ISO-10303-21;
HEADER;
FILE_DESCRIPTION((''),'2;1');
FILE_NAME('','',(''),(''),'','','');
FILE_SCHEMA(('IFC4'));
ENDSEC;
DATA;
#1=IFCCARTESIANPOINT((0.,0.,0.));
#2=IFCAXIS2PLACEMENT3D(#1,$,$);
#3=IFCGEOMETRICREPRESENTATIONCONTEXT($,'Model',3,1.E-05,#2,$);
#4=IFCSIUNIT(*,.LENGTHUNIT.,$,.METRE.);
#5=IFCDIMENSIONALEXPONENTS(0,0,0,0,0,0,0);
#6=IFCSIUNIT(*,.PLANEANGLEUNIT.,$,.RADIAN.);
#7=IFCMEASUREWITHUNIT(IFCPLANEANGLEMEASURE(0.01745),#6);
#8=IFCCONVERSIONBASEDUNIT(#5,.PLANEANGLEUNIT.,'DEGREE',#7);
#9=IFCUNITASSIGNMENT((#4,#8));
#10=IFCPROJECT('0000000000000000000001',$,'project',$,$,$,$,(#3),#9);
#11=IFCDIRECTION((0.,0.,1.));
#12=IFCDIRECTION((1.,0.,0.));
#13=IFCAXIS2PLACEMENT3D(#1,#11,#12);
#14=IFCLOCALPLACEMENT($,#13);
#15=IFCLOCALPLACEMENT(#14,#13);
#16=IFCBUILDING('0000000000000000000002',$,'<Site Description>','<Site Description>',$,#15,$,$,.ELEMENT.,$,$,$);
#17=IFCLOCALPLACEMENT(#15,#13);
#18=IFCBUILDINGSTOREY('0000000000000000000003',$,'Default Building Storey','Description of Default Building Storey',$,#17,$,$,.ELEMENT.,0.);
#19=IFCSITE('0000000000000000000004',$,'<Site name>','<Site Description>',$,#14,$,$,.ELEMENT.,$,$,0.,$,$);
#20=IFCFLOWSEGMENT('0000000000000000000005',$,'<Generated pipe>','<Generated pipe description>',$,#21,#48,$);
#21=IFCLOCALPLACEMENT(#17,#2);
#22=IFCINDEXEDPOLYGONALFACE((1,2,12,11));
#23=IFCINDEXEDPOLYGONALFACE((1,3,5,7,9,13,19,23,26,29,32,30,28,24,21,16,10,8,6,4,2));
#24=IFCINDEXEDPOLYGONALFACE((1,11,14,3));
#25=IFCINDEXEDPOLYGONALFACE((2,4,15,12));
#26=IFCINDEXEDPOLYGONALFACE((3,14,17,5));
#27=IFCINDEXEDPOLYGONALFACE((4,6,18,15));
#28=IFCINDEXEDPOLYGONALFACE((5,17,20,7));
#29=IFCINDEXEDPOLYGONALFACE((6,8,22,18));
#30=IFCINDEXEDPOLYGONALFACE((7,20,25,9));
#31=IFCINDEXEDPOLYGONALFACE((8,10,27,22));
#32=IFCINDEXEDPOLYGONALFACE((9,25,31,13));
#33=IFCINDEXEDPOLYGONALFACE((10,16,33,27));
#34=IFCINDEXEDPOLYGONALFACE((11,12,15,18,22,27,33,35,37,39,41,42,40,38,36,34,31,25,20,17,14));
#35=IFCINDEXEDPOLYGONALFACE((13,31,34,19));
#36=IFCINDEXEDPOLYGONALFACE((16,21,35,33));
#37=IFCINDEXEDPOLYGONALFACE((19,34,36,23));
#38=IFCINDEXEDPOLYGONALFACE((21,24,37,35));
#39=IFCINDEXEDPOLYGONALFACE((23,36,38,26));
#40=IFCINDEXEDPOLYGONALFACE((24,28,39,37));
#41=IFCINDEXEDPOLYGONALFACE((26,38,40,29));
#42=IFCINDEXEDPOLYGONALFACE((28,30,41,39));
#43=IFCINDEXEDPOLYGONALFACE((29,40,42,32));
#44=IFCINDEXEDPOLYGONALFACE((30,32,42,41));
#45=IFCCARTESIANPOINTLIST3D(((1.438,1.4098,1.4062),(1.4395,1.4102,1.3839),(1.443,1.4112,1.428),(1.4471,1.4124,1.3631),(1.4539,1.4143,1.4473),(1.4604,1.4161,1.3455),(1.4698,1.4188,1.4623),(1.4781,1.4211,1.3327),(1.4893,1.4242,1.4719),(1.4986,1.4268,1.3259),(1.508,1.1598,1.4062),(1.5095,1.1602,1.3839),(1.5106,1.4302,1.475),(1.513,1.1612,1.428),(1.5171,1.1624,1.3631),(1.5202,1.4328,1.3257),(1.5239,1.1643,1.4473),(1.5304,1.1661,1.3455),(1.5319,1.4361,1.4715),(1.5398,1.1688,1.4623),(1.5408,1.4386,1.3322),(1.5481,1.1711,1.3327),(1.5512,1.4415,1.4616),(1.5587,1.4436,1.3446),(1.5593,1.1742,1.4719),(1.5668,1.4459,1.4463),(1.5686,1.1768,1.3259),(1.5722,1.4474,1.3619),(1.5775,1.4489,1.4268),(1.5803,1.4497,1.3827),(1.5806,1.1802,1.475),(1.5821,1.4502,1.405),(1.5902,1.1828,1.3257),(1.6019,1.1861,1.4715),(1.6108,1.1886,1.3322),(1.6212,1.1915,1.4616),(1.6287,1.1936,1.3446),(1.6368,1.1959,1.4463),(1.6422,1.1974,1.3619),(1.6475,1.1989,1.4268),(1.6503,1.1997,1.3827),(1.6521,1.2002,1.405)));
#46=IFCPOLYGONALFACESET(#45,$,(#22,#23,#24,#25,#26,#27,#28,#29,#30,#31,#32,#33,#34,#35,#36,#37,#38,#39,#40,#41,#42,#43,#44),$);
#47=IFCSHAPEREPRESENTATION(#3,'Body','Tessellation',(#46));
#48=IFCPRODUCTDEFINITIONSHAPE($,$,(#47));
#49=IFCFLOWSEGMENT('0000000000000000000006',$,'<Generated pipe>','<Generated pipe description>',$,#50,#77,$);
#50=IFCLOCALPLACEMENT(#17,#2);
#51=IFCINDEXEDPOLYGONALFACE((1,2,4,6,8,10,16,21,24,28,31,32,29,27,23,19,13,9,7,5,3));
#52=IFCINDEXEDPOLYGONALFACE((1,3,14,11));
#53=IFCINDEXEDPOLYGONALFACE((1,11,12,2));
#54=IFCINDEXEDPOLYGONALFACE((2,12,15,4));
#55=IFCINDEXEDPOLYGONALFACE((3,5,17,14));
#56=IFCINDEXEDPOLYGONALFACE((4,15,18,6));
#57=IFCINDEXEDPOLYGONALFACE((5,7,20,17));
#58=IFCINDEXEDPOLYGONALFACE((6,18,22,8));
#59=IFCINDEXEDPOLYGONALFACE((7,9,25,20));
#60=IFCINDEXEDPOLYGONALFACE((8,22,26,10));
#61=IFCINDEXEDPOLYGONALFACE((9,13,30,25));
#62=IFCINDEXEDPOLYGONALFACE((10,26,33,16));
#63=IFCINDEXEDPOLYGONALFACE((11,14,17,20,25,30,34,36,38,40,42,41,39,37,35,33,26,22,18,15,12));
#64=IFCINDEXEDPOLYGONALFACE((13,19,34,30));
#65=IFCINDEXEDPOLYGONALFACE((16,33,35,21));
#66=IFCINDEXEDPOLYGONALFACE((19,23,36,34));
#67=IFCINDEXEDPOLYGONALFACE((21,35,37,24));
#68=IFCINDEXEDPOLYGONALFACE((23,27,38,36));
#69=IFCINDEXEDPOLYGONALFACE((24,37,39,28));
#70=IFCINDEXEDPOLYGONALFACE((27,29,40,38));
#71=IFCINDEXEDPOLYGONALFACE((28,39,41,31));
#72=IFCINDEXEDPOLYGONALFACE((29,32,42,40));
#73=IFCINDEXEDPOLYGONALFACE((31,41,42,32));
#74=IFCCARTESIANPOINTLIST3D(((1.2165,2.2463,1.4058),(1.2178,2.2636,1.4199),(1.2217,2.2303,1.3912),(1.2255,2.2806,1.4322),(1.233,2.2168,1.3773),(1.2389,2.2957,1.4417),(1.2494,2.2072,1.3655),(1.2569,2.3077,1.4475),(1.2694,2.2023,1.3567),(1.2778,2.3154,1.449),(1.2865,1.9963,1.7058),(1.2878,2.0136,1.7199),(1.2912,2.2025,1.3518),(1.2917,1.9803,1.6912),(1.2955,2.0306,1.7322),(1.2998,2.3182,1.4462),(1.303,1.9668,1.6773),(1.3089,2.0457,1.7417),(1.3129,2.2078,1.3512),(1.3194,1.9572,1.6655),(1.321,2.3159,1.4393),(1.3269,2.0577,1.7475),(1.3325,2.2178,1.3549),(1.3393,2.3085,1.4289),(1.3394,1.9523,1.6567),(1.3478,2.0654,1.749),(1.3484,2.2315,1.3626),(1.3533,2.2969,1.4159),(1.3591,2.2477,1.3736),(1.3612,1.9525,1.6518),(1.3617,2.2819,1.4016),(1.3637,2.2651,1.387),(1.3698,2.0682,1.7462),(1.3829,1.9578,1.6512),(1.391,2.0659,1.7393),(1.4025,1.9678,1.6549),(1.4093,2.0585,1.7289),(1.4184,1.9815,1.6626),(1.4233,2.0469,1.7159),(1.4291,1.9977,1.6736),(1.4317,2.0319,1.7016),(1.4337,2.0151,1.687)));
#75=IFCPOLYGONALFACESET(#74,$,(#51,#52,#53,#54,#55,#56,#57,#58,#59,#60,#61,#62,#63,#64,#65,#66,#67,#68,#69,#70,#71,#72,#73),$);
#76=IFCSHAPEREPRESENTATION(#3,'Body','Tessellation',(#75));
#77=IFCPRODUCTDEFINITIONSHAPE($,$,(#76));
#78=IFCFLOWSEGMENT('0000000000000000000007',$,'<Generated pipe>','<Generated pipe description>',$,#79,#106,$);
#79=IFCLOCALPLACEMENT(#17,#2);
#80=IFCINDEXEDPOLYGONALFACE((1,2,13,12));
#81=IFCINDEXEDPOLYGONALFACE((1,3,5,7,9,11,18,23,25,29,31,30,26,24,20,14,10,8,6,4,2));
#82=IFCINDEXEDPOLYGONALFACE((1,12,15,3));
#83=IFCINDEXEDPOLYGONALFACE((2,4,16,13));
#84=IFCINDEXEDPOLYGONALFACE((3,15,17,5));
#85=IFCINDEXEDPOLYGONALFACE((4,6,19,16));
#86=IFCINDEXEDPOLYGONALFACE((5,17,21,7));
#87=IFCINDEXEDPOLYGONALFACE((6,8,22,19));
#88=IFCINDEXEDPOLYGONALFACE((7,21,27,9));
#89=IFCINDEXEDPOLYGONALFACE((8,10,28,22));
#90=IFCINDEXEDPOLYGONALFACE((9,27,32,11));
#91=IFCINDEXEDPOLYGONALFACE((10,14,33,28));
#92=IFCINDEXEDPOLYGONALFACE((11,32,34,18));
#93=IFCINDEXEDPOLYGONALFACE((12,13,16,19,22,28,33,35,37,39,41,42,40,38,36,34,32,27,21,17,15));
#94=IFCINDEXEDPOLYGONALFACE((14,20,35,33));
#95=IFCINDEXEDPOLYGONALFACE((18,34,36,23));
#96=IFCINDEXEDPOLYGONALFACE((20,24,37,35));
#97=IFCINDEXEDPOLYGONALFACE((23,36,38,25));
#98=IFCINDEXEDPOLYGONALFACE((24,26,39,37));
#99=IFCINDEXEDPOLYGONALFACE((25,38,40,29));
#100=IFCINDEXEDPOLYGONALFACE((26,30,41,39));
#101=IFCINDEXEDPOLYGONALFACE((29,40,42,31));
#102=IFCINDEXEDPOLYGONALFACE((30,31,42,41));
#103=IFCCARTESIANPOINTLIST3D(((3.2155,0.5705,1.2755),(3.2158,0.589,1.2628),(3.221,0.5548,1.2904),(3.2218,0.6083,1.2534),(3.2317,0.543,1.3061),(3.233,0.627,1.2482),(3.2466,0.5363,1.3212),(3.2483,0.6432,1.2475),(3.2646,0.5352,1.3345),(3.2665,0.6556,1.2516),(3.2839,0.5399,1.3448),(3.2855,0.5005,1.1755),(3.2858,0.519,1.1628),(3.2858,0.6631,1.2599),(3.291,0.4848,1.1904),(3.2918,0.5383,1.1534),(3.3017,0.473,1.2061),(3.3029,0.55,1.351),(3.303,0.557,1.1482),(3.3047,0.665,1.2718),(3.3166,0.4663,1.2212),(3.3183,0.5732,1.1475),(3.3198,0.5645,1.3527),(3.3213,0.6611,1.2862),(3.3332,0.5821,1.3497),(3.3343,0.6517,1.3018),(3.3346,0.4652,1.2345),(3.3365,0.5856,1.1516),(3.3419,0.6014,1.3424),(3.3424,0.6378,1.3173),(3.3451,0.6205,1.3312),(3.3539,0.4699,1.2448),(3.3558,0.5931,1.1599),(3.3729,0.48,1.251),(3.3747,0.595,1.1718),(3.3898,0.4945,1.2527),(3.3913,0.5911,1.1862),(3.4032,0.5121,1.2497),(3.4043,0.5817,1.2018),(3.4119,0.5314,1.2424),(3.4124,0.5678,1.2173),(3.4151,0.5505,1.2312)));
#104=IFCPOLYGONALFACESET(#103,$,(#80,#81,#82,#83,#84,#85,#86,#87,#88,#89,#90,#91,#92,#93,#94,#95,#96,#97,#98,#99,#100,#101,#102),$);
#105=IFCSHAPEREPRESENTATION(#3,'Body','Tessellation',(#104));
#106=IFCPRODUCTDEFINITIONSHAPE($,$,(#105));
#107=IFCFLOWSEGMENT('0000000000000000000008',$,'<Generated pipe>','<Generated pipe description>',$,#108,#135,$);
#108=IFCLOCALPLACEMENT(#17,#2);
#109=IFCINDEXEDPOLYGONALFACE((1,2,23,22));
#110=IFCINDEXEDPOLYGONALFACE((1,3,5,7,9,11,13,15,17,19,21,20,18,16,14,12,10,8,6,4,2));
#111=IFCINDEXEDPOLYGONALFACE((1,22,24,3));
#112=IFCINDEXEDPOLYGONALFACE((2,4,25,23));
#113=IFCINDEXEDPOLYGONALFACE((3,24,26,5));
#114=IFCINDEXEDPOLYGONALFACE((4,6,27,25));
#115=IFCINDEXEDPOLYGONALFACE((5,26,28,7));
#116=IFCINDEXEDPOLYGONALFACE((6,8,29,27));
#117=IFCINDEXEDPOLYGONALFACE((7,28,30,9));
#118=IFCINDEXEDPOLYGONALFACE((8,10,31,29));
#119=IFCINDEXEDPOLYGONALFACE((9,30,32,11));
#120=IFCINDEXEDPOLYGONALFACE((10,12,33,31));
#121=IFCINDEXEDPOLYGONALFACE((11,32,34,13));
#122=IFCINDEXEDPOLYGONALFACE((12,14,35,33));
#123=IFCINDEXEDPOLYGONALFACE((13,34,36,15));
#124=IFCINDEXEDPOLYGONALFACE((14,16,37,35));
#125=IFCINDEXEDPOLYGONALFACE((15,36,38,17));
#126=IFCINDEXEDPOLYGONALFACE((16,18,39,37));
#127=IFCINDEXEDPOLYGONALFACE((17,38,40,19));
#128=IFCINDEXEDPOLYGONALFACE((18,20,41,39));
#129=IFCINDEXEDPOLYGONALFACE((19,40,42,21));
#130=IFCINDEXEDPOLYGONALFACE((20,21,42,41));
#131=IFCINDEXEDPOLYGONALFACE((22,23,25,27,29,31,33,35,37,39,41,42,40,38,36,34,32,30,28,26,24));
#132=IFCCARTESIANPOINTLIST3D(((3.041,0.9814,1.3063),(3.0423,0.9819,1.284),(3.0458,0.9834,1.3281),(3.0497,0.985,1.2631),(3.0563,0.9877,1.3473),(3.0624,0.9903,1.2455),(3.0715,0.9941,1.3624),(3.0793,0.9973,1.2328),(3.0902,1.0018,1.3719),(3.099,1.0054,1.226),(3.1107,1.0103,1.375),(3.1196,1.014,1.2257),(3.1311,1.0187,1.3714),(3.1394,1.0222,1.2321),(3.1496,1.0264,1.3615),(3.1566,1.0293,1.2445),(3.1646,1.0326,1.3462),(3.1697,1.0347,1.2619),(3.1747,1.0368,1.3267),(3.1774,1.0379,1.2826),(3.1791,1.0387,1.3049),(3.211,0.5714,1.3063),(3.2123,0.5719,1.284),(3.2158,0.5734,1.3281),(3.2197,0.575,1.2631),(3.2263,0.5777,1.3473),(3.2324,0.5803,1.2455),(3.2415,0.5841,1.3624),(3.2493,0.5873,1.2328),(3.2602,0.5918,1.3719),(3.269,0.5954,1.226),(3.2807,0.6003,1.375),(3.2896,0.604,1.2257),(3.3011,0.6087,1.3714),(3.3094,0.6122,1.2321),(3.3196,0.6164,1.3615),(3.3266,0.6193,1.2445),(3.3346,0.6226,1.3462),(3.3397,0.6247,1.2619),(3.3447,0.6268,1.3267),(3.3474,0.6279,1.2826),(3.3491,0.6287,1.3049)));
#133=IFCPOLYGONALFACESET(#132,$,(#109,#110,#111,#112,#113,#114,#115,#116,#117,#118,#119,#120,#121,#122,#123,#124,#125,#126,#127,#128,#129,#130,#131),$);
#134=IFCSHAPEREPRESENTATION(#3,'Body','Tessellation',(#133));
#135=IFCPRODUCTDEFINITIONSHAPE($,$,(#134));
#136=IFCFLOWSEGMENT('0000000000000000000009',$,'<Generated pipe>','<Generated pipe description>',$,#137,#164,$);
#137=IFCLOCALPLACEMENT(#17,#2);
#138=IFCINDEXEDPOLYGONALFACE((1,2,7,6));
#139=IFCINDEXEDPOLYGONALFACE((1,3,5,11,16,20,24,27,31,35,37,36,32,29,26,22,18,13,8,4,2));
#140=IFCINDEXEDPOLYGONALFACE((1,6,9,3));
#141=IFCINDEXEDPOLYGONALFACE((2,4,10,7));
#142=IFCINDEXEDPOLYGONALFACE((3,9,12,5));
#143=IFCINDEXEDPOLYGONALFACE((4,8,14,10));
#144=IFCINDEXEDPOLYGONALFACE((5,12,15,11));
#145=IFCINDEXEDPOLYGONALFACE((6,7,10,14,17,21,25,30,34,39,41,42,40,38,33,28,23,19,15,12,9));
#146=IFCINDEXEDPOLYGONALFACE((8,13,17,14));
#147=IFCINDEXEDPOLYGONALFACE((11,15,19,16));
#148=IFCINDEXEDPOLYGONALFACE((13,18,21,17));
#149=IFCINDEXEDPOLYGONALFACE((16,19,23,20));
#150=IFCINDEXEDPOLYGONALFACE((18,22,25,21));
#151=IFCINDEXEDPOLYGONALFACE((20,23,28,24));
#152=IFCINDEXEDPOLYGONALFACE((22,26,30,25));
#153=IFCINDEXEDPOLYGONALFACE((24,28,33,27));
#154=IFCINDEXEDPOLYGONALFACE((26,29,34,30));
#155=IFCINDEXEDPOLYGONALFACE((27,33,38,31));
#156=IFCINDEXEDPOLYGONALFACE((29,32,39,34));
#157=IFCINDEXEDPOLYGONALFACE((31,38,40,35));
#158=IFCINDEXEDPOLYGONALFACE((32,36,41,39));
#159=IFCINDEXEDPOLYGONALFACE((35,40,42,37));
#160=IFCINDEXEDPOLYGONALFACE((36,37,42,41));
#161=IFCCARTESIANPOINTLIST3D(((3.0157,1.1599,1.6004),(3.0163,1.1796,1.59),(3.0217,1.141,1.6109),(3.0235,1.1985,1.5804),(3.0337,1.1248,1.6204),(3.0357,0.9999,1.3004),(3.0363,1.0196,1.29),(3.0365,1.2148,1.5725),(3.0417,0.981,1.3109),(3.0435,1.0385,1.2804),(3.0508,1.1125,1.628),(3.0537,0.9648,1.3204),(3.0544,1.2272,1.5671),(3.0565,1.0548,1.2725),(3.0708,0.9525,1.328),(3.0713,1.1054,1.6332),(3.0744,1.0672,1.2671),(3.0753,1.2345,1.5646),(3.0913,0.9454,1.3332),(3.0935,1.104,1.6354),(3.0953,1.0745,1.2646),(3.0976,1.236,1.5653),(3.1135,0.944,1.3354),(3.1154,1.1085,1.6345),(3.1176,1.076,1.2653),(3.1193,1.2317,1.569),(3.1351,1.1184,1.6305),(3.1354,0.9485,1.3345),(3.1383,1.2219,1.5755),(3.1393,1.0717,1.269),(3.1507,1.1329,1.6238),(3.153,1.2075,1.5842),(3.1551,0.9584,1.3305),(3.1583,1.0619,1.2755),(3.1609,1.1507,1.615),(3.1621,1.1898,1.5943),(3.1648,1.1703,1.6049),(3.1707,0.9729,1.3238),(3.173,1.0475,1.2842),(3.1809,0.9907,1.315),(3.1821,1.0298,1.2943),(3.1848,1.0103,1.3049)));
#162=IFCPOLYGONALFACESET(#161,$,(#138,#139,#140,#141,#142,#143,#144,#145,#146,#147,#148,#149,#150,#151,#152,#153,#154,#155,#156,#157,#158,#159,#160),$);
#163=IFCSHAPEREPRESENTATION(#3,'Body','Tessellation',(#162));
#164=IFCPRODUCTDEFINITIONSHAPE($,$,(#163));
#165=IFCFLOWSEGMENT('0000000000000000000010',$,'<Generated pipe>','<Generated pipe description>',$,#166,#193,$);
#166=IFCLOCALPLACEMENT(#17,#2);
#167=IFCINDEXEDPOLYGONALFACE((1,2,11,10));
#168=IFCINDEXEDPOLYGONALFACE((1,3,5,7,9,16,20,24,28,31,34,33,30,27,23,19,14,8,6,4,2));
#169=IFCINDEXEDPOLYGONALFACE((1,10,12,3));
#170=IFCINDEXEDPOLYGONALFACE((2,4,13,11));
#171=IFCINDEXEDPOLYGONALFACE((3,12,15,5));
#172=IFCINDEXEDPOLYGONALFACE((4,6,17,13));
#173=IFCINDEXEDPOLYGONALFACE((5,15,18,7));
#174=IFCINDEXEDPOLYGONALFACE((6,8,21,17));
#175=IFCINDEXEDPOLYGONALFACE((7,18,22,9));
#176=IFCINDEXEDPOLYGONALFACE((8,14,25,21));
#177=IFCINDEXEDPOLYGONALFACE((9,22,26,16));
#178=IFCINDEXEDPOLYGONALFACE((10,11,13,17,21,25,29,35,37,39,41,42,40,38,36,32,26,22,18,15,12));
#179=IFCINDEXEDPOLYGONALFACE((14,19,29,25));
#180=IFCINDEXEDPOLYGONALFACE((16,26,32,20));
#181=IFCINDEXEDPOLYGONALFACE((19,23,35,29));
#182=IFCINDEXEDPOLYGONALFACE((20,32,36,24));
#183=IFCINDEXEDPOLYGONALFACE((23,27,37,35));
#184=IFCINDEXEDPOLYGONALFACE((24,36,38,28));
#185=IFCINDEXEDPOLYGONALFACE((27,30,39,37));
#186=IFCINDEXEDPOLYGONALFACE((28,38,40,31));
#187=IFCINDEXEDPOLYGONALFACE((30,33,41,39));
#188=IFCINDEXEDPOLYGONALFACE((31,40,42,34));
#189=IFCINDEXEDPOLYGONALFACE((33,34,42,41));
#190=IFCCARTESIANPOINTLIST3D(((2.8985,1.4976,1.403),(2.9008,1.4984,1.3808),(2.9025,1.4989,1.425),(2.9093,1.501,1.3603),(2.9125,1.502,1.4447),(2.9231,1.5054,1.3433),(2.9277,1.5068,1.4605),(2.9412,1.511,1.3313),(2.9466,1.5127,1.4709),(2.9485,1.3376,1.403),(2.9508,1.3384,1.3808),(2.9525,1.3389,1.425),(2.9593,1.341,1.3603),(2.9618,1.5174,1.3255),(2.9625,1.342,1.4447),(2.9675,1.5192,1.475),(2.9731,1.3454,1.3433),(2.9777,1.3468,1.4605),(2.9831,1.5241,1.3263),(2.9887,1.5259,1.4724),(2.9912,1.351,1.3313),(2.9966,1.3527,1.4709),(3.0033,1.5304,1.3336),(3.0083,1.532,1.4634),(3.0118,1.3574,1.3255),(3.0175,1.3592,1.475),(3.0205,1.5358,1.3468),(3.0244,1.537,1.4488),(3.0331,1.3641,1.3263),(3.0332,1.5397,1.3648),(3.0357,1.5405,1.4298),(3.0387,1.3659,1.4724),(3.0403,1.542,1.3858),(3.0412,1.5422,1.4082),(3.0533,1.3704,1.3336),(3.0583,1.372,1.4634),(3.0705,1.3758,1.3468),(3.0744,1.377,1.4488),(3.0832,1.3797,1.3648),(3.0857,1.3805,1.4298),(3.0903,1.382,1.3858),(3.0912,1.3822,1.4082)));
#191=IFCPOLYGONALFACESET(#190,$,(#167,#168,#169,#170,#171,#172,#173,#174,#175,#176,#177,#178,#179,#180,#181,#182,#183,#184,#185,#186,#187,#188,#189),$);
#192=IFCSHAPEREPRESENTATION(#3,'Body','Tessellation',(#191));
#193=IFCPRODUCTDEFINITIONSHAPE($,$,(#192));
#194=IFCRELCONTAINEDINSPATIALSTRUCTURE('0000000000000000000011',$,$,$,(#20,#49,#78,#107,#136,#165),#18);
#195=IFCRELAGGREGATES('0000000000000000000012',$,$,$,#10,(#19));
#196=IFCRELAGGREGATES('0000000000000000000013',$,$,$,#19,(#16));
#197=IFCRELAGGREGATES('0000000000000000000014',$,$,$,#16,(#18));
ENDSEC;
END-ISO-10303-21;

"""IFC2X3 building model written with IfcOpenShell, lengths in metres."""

from ifc_helpers import new_model, entity, si_unit, converted_unit, frame, origin, origin_with_axes, origin_2d_with_axis, place, context, project, spatial, circle, extrude, element, save


model = new_model("IFC2X3")

# Units and contexts
model_context = context("Model", 3, precision=1e-05, world=origin())
ifc_project = project(units=[si_unit("LENGTHUNIT", "METRE"), converted_unit("PLANEANGLEUNIT", "DEGREE", entity("IfcPlaneAngleMeasure", 0.01745), si_unit("PLANEANGLEUNIT", "RADIAN"), dimensions=[0, 0, 0, 0, 0, 0, 0])], contexts=[model_context])

# Site, building, storey
site_placement = place(None, origin_with_axes())
site = spatial("IfcSite", under=ifc_project, at=site_placement, Name="<Site name>", Description="<Site Description>", CompositionType="ELEMENT", RefElevation=0.0)
building_placement = place(site_placement, origin_with_axes())
building = spatial("IfcBuilding", under=site, at=building_placement, Name="<Site Description>", Description="<Site Description>", CompositionType="ELEMENT")
storey_placement = place(building_placement, origin_with_axes())
storey = spatial("IfcBuildingStorey", under=building, at=storey_placement, Name="Default Building Storey", Description="Description of Default Building Storey", CompositionType="ELEMENT", Elevation=0.0)

# Flow segments
flow_segment_1_placement = place(storey_placement, frame((1.58, 1.18, 1.4), z_axis=(-0.26963, 0.962964, 0.0), x_axis=(0.96085, 0.269038, 0.066219)))
element("IfcFlowSegment", 1, at=flow_segment_1_placement, inside=storey, Name="<Generated pipe>", Description="<Generated pipe description>", context=model_context, shape_type="SweptSolid", body=[
    extrude(circle(Radius=0.075, at=origin_2d_with_axis()), origin_with_axes(), (0.0, 0.0, 1.0), 0.2596),
])
flow_segment_2_placement = place(storey_placement, frame((1.36, 2.01, 1.7), z_axis=(-0.176439, 0.630141, -0.756169), x_axis=(0.131235, 0.776422, 0.616397)))
element("IfcFlowSegment", 2, at=flow_segment_2_placement, inside=storey, Name="<Generated pipe>", Description="<Generated pipe description>", context=model_context, shape_type="SweptSolid", body=[
    extrude(circle(Radius=0.075, at=origin_2d_with_axis()), origin_with_axes(), (0.0, 0.0, 1.0), 0.3967),
])
flow_segment_3_placement = place(storey_placement, frame((3.35, 0.53, 1.2), z_axis=(-0.497468, 0.497468, 0.710669), x_axis=(0.867386, 0.273067, 0.416023)))
element("IfcFlowSegment", 3, at=flow_segment_3_placement, inside=storey, Name="<Generated pipe>", Description="<Generated pipe description>", context=model_context, shape_type="SweptSolid", body=[
    extrude(circle(Radius=0.075, at=origin_2d_with_axis()), origin_with_axes(), (0.0, 0.0, 1.0), 0.1407),
])
flow_segment_4_placement = place(storey_placement, frame((3.28, 0.6, 1.3), z_axis=(-0.383015, 0.923742, 0.0), x_axis=(0.86319, 0.357908, 0.356097)))
element("IfcFlowSegment", 4, at=flow_segment_4_placement, inside=storey, Name="<Generated pipe>", Description="<Generated pipe description>", context=model_context, shape_type="SweptSolid", body=[
    extrude(circle(Radius=0.075, at=origin_2d_with_axis()), origin_with_axes(), (0.0, 0.0, 1.0), 0.4438),
])
flow_segment_5_placement = place(storey_placement, frame((3.11, 1.01, 1.3), z_axis=(-0.058722, 0.469776, 0.88083), x_axis=(0.64358, 0.692323, -0.326334)))
element("IfcFlowSegment", 5, at=flow_segment_5_placement, inside=storey, Name="<Generated pipe>", Description="<Generated pipe description>", context=model_context, shape_type="SweptSolid", body=[
    extrude(circle(Radius=0.075, at=origin_2d_with_axis()), origin_with_axes(), (0.0, 0.0, 1.0), 0.3406),
])
flow_segment_6_placement = place(storey_placement, frame((3.02, 1.36, 1.4), z_axis=(-0.298275, 0.95448, 0.0), x_axis=(0.510141, 0.159419, 0.845188)))
element("IfcFlowSegment", 6, at=flow_segment_6_placement, inside=storey, Name="<Generated pipe>", Description="<Generated pipe description>", context=model_context, shape_type="SweptSolid", body=[
    extrude(circle(Radius=0.075, at=origin_2d_with_axis()), origin_with_axes(), (0.0, 0.0, 1.0), 0.1676),
])

save(model, "model.ifc")
